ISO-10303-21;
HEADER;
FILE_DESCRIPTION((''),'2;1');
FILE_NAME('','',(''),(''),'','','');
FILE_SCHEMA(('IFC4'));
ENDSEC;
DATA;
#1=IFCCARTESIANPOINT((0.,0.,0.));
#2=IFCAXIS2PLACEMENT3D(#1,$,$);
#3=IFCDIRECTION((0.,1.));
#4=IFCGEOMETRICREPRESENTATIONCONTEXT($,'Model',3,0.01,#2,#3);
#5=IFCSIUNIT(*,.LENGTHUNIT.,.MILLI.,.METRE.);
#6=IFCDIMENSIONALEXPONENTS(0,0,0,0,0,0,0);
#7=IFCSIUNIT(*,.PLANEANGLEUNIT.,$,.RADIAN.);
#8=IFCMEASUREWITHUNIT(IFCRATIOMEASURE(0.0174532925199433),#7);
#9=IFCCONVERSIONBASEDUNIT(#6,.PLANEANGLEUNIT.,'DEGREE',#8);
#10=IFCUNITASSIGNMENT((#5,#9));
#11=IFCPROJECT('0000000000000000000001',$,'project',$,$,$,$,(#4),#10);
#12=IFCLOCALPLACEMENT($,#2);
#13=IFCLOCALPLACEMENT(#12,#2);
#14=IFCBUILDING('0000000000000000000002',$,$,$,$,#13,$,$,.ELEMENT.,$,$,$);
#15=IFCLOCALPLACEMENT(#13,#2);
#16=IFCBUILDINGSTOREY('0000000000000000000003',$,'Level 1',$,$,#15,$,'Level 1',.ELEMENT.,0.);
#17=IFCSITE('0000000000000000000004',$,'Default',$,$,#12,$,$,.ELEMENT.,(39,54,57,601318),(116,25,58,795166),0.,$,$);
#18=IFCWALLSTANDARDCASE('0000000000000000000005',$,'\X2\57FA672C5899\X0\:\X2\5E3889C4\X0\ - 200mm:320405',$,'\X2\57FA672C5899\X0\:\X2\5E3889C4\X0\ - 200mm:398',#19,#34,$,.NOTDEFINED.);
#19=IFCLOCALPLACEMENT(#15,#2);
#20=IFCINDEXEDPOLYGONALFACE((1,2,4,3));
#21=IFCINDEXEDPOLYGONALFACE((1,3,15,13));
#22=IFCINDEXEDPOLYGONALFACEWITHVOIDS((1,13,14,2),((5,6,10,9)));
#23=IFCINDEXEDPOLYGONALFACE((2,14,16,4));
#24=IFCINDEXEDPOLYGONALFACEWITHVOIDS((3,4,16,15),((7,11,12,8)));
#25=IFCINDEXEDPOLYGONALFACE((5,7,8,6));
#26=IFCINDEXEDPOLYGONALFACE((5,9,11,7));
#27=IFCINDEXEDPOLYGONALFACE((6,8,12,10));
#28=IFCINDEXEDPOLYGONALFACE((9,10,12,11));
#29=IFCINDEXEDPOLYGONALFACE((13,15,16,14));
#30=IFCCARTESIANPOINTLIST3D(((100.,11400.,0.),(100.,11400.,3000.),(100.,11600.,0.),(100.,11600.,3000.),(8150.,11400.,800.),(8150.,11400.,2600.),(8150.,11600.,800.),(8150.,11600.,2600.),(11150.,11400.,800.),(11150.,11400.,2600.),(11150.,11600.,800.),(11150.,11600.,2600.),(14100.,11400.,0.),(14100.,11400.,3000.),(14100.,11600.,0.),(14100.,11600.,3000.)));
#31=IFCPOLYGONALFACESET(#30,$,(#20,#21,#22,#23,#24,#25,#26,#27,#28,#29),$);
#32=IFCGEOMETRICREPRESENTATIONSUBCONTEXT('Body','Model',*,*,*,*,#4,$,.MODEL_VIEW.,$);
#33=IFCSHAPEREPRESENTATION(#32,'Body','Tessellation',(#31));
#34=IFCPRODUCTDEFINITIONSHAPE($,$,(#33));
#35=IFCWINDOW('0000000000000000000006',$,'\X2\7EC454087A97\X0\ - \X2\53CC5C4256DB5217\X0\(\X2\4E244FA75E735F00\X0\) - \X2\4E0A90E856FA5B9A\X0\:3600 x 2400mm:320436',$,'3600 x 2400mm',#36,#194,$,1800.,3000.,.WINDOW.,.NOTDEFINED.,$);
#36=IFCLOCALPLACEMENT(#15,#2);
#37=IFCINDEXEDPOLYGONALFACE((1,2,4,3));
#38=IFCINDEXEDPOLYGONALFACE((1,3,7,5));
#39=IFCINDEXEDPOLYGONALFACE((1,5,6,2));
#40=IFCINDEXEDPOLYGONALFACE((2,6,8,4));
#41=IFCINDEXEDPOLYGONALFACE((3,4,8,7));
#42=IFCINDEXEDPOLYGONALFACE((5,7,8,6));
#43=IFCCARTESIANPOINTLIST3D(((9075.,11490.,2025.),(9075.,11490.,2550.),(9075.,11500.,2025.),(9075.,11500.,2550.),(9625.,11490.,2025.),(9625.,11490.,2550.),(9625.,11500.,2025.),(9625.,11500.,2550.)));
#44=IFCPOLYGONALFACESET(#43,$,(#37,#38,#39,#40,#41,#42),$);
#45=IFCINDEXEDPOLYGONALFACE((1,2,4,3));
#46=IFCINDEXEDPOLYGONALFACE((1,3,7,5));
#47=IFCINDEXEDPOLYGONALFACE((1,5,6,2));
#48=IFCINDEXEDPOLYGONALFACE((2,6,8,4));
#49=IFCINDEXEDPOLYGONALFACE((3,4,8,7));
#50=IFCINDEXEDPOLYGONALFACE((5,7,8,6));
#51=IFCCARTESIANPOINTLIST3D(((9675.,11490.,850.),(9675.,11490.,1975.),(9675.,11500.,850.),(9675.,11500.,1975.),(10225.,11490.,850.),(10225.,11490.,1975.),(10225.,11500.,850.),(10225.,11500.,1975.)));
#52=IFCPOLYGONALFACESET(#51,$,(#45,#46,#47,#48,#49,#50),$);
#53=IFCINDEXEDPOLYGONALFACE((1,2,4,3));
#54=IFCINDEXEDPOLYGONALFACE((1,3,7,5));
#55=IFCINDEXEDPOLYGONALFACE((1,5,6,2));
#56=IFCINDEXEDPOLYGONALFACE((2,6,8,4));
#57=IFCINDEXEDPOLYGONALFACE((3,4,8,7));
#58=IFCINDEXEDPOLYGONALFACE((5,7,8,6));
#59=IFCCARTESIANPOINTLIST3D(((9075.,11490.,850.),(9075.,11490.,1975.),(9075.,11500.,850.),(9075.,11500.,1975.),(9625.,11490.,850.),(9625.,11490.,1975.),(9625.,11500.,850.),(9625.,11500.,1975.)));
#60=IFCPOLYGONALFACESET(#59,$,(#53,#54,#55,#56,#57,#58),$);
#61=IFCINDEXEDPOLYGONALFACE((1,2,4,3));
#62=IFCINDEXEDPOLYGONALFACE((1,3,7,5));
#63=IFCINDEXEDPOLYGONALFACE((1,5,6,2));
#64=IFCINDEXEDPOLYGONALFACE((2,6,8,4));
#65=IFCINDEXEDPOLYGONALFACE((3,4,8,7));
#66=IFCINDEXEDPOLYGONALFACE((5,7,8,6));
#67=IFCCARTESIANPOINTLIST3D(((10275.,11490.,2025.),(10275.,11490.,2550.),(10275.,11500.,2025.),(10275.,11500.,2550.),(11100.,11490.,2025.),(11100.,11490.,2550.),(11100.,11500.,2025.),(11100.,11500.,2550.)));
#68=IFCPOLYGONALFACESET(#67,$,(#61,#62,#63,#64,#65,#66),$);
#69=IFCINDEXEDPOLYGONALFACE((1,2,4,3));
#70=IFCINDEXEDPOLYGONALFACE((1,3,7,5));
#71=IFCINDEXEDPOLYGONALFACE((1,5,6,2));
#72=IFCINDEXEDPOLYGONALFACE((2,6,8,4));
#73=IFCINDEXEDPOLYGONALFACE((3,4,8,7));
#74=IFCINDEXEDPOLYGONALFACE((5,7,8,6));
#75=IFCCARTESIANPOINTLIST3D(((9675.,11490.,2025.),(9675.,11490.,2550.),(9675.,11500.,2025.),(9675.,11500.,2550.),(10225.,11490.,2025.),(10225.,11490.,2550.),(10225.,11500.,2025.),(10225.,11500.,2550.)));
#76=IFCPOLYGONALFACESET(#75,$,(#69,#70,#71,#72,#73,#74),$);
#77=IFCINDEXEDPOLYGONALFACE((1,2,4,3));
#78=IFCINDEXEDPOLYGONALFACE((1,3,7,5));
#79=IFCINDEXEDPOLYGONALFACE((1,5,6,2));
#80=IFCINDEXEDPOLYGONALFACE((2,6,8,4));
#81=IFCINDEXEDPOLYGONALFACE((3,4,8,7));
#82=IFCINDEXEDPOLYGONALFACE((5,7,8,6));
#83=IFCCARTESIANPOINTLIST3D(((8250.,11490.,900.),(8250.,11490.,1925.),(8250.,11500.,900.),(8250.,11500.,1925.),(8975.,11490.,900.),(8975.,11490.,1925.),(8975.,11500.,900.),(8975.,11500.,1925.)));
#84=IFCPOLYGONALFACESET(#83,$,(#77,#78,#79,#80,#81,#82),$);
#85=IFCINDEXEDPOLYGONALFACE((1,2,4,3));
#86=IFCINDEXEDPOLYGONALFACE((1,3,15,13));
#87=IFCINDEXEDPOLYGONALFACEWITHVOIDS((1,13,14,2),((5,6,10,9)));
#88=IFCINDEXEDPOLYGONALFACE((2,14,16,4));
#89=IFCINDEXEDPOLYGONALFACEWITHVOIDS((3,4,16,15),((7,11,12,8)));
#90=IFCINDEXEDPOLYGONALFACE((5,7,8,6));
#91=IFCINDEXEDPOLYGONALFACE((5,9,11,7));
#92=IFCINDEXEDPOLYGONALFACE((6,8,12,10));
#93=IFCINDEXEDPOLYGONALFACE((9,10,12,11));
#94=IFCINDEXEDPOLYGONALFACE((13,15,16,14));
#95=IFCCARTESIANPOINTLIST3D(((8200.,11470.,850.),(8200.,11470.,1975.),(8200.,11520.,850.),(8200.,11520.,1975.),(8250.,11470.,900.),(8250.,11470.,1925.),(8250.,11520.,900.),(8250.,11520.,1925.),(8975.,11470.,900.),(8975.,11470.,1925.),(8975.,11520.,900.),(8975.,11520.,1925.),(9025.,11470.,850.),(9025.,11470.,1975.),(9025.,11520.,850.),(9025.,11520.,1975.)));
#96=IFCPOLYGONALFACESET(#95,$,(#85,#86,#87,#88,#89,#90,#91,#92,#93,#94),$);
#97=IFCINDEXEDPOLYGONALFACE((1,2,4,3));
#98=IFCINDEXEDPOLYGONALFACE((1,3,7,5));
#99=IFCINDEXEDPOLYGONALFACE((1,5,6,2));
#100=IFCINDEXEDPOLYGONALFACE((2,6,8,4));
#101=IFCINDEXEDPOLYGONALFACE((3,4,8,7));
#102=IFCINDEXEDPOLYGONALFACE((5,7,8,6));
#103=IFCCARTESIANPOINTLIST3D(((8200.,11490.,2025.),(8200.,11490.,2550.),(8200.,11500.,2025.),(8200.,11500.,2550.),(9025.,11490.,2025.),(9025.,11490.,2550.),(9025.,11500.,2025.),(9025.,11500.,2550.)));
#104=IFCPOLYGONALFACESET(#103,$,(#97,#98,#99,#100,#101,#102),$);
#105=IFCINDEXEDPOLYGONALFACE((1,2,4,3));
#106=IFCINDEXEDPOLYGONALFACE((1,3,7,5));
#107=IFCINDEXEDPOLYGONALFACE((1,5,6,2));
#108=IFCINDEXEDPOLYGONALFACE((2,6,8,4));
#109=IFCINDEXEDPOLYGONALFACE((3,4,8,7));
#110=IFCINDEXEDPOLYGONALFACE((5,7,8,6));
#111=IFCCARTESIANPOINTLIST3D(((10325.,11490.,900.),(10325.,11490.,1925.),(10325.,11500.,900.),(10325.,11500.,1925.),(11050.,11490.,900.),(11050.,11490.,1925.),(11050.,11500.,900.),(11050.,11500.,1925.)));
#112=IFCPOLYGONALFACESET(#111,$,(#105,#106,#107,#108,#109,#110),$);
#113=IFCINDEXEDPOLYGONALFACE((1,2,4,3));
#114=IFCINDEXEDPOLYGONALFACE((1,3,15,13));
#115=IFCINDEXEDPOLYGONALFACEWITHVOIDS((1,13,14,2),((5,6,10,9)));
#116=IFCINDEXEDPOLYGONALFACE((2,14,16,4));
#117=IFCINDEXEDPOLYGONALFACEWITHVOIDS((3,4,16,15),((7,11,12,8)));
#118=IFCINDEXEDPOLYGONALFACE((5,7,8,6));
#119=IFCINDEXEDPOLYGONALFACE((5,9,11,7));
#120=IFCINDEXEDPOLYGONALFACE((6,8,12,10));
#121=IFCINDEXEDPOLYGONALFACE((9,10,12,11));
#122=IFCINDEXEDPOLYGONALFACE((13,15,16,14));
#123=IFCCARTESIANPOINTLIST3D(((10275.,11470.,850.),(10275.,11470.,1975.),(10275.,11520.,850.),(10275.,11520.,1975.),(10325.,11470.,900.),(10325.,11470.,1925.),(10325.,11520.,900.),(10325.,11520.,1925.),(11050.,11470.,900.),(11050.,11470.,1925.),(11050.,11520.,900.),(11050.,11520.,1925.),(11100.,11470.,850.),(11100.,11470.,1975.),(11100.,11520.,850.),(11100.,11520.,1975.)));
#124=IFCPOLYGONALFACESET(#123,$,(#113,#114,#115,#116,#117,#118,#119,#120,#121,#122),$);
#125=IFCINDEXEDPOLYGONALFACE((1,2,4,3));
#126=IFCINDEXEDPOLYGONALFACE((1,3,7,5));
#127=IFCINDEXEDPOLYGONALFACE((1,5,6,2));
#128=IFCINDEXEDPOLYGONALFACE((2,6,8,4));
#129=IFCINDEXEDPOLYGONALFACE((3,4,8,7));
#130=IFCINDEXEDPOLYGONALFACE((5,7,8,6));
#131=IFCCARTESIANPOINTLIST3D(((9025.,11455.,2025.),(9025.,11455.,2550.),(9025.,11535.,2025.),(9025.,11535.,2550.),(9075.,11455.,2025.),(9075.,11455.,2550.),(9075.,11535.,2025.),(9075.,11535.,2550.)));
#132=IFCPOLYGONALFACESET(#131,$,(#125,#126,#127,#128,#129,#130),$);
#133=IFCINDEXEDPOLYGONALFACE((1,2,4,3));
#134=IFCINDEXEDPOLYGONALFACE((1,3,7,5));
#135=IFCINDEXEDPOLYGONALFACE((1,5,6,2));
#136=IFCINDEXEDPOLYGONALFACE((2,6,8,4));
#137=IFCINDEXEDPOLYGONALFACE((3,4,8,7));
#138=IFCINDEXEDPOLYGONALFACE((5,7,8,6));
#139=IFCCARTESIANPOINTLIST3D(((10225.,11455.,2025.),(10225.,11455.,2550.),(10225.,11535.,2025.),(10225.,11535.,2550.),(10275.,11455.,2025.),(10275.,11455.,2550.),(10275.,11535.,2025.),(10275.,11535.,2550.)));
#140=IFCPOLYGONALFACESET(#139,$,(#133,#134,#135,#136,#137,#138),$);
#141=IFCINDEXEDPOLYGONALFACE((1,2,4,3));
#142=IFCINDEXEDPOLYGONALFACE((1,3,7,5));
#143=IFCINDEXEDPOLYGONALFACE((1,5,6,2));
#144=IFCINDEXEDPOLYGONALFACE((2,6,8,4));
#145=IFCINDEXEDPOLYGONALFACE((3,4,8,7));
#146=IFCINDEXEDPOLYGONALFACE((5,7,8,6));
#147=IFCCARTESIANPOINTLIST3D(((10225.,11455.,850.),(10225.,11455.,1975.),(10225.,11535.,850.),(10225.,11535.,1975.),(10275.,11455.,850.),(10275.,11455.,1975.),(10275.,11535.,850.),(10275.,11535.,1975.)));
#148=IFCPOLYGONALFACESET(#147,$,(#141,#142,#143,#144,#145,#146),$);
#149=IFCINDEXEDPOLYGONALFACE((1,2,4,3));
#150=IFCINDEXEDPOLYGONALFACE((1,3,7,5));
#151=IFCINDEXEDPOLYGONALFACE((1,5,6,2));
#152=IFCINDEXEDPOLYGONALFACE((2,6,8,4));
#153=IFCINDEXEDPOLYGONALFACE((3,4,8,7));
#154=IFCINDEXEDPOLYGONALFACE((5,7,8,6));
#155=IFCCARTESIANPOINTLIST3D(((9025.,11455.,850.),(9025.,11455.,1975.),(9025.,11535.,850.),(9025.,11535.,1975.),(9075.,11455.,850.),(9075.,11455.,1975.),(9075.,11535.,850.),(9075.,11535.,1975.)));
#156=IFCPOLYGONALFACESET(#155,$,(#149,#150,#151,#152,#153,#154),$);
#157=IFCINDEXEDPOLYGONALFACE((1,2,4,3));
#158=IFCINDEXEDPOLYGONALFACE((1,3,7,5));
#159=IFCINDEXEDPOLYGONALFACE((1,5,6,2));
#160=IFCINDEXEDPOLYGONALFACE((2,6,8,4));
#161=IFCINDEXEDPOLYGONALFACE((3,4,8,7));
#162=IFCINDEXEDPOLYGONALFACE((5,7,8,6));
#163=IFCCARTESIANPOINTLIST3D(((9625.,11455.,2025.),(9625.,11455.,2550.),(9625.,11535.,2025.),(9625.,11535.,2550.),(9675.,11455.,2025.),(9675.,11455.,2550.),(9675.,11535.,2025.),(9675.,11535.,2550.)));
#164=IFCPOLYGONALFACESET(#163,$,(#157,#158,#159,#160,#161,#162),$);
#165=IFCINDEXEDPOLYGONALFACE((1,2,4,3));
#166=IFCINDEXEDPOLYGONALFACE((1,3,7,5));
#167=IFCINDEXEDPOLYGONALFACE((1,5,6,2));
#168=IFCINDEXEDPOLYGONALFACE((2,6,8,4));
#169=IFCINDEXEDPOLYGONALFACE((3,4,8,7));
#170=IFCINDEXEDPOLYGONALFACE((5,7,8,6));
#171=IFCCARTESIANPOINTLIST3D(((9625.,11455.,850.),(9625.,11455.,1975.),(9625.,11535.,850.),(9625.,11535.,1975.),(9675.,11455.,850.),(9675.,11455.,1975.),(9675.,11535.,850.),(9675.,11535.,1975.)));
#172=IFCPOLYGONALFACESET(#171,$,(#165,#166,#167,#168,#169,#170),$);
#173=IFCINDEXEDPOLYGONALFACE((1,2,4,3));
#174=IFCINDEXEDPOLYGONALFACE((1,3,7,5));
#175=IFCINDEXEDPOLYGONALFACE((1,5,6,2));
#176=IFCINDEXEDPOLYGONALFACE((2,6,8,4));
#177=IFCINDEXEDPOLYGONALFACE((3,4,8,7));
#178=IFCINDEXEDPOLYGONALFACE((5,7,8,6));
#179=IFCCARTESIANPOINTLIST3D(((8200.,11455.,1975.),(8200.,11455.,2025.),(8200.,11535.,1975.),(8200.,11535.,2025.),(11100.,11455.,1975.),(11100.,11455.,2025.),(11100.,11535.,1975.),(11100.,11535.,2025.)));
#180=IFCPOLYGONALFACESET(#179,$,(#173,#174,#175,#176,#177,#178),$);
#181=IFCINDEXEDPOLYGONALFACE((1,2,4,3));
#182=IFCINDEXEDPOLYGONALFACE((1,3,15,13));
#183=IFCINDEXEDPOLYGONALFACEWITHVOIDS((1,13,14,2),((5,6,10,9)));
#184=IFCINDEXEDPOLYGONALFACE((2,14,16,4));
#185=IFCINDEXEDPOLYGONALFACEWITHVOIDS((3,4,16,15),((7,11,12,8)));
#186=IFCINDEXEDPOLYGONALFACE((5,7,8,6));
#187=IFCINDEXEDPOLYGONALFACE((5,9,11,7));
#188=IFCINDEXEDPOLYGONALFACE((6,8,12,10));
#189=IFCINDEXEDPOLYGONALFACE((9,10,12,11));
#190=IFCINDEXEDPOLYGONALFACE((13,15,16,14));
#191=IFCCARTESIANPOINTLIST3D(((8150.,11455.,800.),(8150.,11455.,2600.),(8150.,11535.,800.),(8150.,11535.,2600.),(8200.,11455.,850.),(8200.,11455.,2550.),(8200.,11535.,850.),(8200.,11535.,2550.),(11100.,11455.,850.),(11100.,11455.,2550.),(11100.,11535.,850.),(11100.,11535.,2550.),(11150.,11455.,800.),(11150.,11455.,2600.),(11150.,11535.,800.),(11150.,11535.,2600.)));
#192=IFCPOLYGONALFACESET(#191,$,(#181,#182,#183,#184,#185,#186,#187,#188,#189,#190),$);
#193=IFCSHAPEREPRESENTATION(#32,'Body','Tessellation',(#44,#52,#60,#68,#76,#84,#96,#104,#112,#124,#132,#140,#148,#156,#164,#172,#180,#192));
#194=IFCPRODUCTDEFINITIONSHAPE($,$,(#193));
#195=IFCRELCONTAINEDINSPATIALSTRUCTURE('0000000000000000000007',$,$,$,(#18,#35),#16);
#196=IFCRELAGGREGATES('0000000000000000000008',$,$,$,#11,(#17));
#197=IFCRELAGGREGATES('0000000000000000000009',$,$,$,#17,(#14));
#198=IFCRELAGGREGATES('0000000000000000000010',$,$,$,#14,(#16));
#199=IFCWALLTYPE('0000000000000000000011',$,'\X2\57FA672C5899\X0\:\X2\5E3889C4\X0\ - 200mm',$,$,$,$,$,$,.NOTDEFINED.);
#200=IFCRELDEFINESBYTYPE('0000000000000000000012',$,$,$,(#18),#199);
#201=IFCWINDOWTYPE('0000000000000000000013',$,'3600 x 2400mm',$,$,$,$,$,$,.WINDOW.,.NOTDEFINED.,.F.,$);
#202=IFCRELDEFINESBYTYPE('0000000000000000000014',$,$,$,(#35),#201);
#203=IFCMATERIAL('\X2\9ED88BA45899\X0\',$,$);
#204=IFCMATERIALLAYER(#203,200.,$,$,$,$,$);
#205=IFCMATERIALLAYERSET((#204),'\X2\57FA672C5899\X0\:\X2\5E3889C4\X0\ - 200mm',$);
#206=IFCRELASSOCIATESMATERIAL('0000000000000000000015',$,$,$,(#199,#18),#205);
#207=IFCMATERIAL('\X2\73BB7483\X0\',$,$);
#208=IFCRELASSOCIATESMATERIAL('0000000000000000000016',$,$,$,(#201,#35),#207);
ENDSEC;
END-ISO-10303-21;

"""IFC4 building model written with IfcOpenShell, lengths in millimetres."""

from ifc_helpers import new_model, entity, si_unit, converted_unit, direction, frame, frame_2d, origin, origin_2d_with_axis, place, context, subcontext, project, spatial, polyline, rectangle, outline, extrude, source, transform, mapped, material, layer, layer_set, layer_usage, type_object, type_shapes, element, fill, save


model = new_model("IFC4")

# Units and contexts
model_context = context("Model", 3, precision=0.01, world=origin(), true_north=direction((0.0, 1.0)))
body_context = subcontext(model_context, "Body", "Model", "MODEL_VIEW")
ifc_project = project(units=[si_unit("LENGTHUNIT", "METRE", prefix="MILLI"), converted_unit("PLANEANGLEUNIT", "DEGREE", entity("IfcRatioMeasure", 0.0174532925199433), si_unit("PLANEANGLEUNIT", "RADIAN"), dimensions=[0, 0, 0, 0, 0, 0, 0])], contexts=[model_context])

# Site, building, storey
site_placement = place(None, origin())
site = spatial("IfcSite", under=ifc_project, at=site_placement, Name="Default", CompositionType="ELEMENT", RefLatitude=(39, 54, 57, 601318), RefLongitude=(116, 25, 58, 795166), RefElevation=0.0)
building_placement = place(site_placement, origin())
building = spatial("IfcBuilding", under=site, at=building_placement, CompositionType="ELEMENT")
storey_placement = place(building_placement, origin())
storey = spatial("IfcBuildingStorey", under=building, at=storey_placement, Name="Level 1", LongName="Level 1", CompositionType="ELEMENT", Elevation=0.0)

# Shared definitions
ifc_material_1 = material(Name="默认墙")
ifc_layer_1 = layer(ifc_material_1, 200.0)
ifc_layer_set_1 = layer_set([ifc_layer_1], Name="基本墙:常规 - 200mm")
wall_type = type_object("IfcWallType", Name="基本墙:常规 - 200mm", PredefinedType="NOTDEFINED", material=ifc_layer_set_1)
ifc_material_2 = material(Name="玻璃")

# Wall, opening, window
ifc_layer_usage_1 = layer_usage(ifc_layer_set_1, "AXIS2", "NEGATIVE", 100.0)
wall_1_placement = place(storey_placement, frame((100.0, 11500.0, 0.0)))
wall_1 = element("IfcWallStandardCase", 1, at=wall_1_placement, inside=storey, type_object=wall_type, material=ifc_layer_usage_1, Name="基本墙:常规 - 200mm:320405", ObjectType="基本墙:常规 - 200mm:398", PredefinedType="NOTDEFINED", context=body_context, shape_type="SweptSolid", body=[
    extrude(rectangle(XDim=14000.0, YDim=200.0, at=frame_2d((7000.0, 0.0), x_axis=(-1.0, 0.0))), origin(), (0.0, 0.0, 1.0), 3000.0),
])
opening_1_placement = place(wall_1_placement, frame((8050.0, -100.0, 800.0)))
opening_1 = element("IfcOpeningElement", 2, at=opening_1_placement, cuts=wall_1, ObjectType="Opening", PredefinedType="OPENING", context=body_context, shape_type="SweptSolid", body=[
    extrude(rectangle(XDim=1800.0, YDim=3000.0, at=frame_2d((900.0, 1500.0), x_axis=(1.0, 0.0))), frame((0.0, 0.0, 0.0), z_axis=(0.0, 1.0, 0.0), x_axis=(0.0, 0.0, 1.0)), (0.0, 0.0, 1.0), 200.0),
])
window_type_1 = type_object("IfcWindowType", Name="3600 x 2400mm", ParameterTakesPrecedence=False, PartitioningType="NOTDEFINED", PredefinedType="WINDOW", material=ifc_material_2)
shared_shape_1 = source(origin(), body_context, "Body", "SweptSolid", [
    extrude(rectangle(XDim=10.0, YDim=550.0, at=origin_2d_with_axis()), frame((1200.0, 95.0, 1225.0), z_axis=(0.0, 0.0, 1.0), x_axis=(0.0, 1.0, 0.0)), (0.0, 0.0, 1.0), 525.0),
    extrude(rectangle(XDim=10.0, YDim=550.0, at=origin_2d_with_axis()), frame((1800.0, 95.0, 50.0), z_axis=(0.0, 0.0, 1.0), x_axis=(0.0, 1.0, 0.0)), (0.0, 0.0, 1.0), 1125.0),
    extrude(rectangle(XDim=10.0, YDim=550.0, at=origin_2d_with_axis()), frame((1200.0, 95.0, 50.0), z_axis=(0.0, 0.0, 1.0), x_axis=(0.0, 1.0, 0.0)), (0.0, 0.0, 1.0), 1125.0),
    extrude(rectangle(XDim=10.0, YDim=825.0, at=frame_2d((0.0, 0.0), x_axis=(1.0, 0.0))), frame((2537.5, 95.0, 1225.0), z_axis=(0.0, 0.0, 1.0), x_axis=(0.0, 1.0, 0.0)), (0.0, 0.0, 1.0), 525.0),
    extrude(rectangle(XDim=10.0, YDim=550.0, at=frame_2d((0.0, 0.0), x_axis=(1.0, 0.0))), frame((1800.0, 95.0, 1225.0), z_axis=(0.0, 0.0, 1.0), x_axis=(0.0, 1.0, 0.0)), (0.0, 0.0, 1.0), 525.0),
    extrude(rectangle(XDim=10.0, YDim=725.0, at=frame_2d((0.0, 0.0), x_axis=(1.0, 0.0))), frame((462.5, 95.0, 100.0), z_axis=(0.0, 0.0, 1.0), x_axis=(0.0, 1.0, 0.0)), (0.0, 0.0, 1.0), 1025.0),
    extrude(outline(polyline([(-562.5, -412.5), (562.5, -412.5), (562.5, 412.5), (-562.5, 412.5), (-562.5, -412.5)]), holes=[polyline([(512.5, -362.5), (-512.5, -362.5), (-512.5, 362.5), (512.5, 362.5), (512.5, -362.5)])]), frame((462.5, 70.0, 612.5), z_axis=(0.0, 1.0, 0.0), x_axis=(0.0, 0.0, -1.0)), (0.0, 0.0, 1.0), 50.0),
    extrude(rectangle(XDim=10.0, YDim=825.0, at=origin_2d_with_axis()), frame((462.5, 95.0, 1225.0), z_axis=(0.0, 0.0, 1.0), x_axis=(0.0, 1.0, 0.0)), (0.0, 0.0, 1.0), 525.0),
    extrude(rectangle(XDim=10.0, YDim=725.0, at=frame_2d((0.0, 0.0), x_axis=(1.0, 0.0))), frame((2537.5, 95.0, 100.0), z_axis=(0.0, 0.0, 1.0), x_axis=(0.0, 1.0, 0.0)), (0.0, 0.0, 1.0), 1025.0),
    extrude(outline(polyline([(-562.5, -412.5), (562.5, -412.5), (562.5, 412.5), (-562.5, 412.5), (-562.5, -412.5)]), holes=[polyline([(512.5, -362.5), (-512.5, -362.5), (-512.5, 362.5), (512.5, 362.5), (512.5, -362.5)])]), frame((2537.5, 70.0, 612.5), z_axis=(0.0, 1.0, 0.0), x_axis=(0.0, 0.0, -1.0)), (0.0, 0.0, 1.0), 50.0),
    extrude(rectangle(XDim=80.0, YDim=50.0, at=origin_2d_with_axis()), frame((900.0, 95.0, 1225.0), z_axis=(0.0, 0.0, 1.0), x_axis=(0.0, -1.0, 0.0)), (0.0, 0.0, 1.0), 525.0),
    extrude(rectangle(XDim=80.0, YDim=50.0, at=frame_2d((0.0, 0.0), x_axis=(1.0, 0.0))), frame((2100.0, 95.0, 1225.0), z_axis=(0.0, 0.0, 1.0), x_axis=(0.0, -1.0, 0.0)), (0.0, 0.0, 1.0), 525.0),
    extrude(rectangle(XDim=80.0, YDim=50.0, at=origin_2d_with_axis()), frame((2100.0, 95.0, 50.0), z_axis=(0.0, 0.0, 1.0), x_axis=(0.0, -1.0, 0.0)), (0.0, 0.0, 1.0), 1125.0),
    extrude(rectangle(XDim=80.0, YDim=50.0, at=origin_2d_with_axis()), frame((900.0, 95.0, 50.0), z_axis=(0.0, 0.0, 1.0), x_axis=(0.0, -1.0, 0.0)), (0.0, 0.0, 1.0), 1125.0),
    extrude(rectangle(XDim=80.0, YDim=50.0, at=frame_2d((0.0, 0.0), x_axis=(1.0, 0.0))), frame((1500.0, 95.0, 1225.0), z_axis=(0.0, 0.0, 1.0), x_axis=(0.0, -1.0, 0.0)), (0.0, 0.0, 1.0), 525.0),
    extrude(rectangle(XDim=80.0, YDim=50.0, at=origin_2d_with_axis()), frame((1500.0, 95.0, 50.0), z_axis=(0.0, 0.0, 1.0), x_axis=(0.0, -1.0, 0.0)), (0.0, 0.0, 1.0), 1125.0),
    extrude(rectangle(XDim=80.0, YDim=2900.0, at=frame_2d((0.0, 0.0), x_axis=(1.0, 0.0))), frame((1500.0, 95.0, 1175.0), z_axis=(0.0, 0.0, 1.0), x_axis=(0.0, -1.0, 0.0)), (0.0, 0.0, 1.0), 50.0),
    extrude(outline(polyline([(-1500.0, -900.0), (1500.0, -900.0), (1500.0, 900.0), (-1500.0, 900.0), (-1500.0, -900.0)]), holes=[polyline([(1450.0, -850.0), (-1450.0, -850.0), (-1450.0, 850.0), (1450.0, 850.0), (1450.0, -850.0)])]), frame((1500.0, 55.0, 900.0), z_axis=(0.0, 1.0, 0.0), x_axis=(1.0, 0.0, 0.0)), (0.0, 0.0, 1.0), 80.0),
])
type_shapes(window_type_1, [shared_shape_1])
window_1_placement = place(opening_1_placement, origin())
window_1 = element("IfcWindow", 3, at=window_1_placement, inside=storey, type_object=window_type_1, material=ifc_material_2, Name="组合窗 - 双层四列(两侧平开) - 上部固定:3600 x 2400mm:320436", ObjectType="3600 x 2400mm", OverallHeight=1800.0, OverallWidth=3000.0, PartitioningType="NOTDEFINED", PredefinedType="WINDOW", context=body_context, shape_type="MappedRepresentation", body=[
    mapped(shared_shape_1, transform((0.0, 0.0, 0.0), scale=1.0)),
])
fill(opening_1, window_1)

save(model, "model.ifc")
